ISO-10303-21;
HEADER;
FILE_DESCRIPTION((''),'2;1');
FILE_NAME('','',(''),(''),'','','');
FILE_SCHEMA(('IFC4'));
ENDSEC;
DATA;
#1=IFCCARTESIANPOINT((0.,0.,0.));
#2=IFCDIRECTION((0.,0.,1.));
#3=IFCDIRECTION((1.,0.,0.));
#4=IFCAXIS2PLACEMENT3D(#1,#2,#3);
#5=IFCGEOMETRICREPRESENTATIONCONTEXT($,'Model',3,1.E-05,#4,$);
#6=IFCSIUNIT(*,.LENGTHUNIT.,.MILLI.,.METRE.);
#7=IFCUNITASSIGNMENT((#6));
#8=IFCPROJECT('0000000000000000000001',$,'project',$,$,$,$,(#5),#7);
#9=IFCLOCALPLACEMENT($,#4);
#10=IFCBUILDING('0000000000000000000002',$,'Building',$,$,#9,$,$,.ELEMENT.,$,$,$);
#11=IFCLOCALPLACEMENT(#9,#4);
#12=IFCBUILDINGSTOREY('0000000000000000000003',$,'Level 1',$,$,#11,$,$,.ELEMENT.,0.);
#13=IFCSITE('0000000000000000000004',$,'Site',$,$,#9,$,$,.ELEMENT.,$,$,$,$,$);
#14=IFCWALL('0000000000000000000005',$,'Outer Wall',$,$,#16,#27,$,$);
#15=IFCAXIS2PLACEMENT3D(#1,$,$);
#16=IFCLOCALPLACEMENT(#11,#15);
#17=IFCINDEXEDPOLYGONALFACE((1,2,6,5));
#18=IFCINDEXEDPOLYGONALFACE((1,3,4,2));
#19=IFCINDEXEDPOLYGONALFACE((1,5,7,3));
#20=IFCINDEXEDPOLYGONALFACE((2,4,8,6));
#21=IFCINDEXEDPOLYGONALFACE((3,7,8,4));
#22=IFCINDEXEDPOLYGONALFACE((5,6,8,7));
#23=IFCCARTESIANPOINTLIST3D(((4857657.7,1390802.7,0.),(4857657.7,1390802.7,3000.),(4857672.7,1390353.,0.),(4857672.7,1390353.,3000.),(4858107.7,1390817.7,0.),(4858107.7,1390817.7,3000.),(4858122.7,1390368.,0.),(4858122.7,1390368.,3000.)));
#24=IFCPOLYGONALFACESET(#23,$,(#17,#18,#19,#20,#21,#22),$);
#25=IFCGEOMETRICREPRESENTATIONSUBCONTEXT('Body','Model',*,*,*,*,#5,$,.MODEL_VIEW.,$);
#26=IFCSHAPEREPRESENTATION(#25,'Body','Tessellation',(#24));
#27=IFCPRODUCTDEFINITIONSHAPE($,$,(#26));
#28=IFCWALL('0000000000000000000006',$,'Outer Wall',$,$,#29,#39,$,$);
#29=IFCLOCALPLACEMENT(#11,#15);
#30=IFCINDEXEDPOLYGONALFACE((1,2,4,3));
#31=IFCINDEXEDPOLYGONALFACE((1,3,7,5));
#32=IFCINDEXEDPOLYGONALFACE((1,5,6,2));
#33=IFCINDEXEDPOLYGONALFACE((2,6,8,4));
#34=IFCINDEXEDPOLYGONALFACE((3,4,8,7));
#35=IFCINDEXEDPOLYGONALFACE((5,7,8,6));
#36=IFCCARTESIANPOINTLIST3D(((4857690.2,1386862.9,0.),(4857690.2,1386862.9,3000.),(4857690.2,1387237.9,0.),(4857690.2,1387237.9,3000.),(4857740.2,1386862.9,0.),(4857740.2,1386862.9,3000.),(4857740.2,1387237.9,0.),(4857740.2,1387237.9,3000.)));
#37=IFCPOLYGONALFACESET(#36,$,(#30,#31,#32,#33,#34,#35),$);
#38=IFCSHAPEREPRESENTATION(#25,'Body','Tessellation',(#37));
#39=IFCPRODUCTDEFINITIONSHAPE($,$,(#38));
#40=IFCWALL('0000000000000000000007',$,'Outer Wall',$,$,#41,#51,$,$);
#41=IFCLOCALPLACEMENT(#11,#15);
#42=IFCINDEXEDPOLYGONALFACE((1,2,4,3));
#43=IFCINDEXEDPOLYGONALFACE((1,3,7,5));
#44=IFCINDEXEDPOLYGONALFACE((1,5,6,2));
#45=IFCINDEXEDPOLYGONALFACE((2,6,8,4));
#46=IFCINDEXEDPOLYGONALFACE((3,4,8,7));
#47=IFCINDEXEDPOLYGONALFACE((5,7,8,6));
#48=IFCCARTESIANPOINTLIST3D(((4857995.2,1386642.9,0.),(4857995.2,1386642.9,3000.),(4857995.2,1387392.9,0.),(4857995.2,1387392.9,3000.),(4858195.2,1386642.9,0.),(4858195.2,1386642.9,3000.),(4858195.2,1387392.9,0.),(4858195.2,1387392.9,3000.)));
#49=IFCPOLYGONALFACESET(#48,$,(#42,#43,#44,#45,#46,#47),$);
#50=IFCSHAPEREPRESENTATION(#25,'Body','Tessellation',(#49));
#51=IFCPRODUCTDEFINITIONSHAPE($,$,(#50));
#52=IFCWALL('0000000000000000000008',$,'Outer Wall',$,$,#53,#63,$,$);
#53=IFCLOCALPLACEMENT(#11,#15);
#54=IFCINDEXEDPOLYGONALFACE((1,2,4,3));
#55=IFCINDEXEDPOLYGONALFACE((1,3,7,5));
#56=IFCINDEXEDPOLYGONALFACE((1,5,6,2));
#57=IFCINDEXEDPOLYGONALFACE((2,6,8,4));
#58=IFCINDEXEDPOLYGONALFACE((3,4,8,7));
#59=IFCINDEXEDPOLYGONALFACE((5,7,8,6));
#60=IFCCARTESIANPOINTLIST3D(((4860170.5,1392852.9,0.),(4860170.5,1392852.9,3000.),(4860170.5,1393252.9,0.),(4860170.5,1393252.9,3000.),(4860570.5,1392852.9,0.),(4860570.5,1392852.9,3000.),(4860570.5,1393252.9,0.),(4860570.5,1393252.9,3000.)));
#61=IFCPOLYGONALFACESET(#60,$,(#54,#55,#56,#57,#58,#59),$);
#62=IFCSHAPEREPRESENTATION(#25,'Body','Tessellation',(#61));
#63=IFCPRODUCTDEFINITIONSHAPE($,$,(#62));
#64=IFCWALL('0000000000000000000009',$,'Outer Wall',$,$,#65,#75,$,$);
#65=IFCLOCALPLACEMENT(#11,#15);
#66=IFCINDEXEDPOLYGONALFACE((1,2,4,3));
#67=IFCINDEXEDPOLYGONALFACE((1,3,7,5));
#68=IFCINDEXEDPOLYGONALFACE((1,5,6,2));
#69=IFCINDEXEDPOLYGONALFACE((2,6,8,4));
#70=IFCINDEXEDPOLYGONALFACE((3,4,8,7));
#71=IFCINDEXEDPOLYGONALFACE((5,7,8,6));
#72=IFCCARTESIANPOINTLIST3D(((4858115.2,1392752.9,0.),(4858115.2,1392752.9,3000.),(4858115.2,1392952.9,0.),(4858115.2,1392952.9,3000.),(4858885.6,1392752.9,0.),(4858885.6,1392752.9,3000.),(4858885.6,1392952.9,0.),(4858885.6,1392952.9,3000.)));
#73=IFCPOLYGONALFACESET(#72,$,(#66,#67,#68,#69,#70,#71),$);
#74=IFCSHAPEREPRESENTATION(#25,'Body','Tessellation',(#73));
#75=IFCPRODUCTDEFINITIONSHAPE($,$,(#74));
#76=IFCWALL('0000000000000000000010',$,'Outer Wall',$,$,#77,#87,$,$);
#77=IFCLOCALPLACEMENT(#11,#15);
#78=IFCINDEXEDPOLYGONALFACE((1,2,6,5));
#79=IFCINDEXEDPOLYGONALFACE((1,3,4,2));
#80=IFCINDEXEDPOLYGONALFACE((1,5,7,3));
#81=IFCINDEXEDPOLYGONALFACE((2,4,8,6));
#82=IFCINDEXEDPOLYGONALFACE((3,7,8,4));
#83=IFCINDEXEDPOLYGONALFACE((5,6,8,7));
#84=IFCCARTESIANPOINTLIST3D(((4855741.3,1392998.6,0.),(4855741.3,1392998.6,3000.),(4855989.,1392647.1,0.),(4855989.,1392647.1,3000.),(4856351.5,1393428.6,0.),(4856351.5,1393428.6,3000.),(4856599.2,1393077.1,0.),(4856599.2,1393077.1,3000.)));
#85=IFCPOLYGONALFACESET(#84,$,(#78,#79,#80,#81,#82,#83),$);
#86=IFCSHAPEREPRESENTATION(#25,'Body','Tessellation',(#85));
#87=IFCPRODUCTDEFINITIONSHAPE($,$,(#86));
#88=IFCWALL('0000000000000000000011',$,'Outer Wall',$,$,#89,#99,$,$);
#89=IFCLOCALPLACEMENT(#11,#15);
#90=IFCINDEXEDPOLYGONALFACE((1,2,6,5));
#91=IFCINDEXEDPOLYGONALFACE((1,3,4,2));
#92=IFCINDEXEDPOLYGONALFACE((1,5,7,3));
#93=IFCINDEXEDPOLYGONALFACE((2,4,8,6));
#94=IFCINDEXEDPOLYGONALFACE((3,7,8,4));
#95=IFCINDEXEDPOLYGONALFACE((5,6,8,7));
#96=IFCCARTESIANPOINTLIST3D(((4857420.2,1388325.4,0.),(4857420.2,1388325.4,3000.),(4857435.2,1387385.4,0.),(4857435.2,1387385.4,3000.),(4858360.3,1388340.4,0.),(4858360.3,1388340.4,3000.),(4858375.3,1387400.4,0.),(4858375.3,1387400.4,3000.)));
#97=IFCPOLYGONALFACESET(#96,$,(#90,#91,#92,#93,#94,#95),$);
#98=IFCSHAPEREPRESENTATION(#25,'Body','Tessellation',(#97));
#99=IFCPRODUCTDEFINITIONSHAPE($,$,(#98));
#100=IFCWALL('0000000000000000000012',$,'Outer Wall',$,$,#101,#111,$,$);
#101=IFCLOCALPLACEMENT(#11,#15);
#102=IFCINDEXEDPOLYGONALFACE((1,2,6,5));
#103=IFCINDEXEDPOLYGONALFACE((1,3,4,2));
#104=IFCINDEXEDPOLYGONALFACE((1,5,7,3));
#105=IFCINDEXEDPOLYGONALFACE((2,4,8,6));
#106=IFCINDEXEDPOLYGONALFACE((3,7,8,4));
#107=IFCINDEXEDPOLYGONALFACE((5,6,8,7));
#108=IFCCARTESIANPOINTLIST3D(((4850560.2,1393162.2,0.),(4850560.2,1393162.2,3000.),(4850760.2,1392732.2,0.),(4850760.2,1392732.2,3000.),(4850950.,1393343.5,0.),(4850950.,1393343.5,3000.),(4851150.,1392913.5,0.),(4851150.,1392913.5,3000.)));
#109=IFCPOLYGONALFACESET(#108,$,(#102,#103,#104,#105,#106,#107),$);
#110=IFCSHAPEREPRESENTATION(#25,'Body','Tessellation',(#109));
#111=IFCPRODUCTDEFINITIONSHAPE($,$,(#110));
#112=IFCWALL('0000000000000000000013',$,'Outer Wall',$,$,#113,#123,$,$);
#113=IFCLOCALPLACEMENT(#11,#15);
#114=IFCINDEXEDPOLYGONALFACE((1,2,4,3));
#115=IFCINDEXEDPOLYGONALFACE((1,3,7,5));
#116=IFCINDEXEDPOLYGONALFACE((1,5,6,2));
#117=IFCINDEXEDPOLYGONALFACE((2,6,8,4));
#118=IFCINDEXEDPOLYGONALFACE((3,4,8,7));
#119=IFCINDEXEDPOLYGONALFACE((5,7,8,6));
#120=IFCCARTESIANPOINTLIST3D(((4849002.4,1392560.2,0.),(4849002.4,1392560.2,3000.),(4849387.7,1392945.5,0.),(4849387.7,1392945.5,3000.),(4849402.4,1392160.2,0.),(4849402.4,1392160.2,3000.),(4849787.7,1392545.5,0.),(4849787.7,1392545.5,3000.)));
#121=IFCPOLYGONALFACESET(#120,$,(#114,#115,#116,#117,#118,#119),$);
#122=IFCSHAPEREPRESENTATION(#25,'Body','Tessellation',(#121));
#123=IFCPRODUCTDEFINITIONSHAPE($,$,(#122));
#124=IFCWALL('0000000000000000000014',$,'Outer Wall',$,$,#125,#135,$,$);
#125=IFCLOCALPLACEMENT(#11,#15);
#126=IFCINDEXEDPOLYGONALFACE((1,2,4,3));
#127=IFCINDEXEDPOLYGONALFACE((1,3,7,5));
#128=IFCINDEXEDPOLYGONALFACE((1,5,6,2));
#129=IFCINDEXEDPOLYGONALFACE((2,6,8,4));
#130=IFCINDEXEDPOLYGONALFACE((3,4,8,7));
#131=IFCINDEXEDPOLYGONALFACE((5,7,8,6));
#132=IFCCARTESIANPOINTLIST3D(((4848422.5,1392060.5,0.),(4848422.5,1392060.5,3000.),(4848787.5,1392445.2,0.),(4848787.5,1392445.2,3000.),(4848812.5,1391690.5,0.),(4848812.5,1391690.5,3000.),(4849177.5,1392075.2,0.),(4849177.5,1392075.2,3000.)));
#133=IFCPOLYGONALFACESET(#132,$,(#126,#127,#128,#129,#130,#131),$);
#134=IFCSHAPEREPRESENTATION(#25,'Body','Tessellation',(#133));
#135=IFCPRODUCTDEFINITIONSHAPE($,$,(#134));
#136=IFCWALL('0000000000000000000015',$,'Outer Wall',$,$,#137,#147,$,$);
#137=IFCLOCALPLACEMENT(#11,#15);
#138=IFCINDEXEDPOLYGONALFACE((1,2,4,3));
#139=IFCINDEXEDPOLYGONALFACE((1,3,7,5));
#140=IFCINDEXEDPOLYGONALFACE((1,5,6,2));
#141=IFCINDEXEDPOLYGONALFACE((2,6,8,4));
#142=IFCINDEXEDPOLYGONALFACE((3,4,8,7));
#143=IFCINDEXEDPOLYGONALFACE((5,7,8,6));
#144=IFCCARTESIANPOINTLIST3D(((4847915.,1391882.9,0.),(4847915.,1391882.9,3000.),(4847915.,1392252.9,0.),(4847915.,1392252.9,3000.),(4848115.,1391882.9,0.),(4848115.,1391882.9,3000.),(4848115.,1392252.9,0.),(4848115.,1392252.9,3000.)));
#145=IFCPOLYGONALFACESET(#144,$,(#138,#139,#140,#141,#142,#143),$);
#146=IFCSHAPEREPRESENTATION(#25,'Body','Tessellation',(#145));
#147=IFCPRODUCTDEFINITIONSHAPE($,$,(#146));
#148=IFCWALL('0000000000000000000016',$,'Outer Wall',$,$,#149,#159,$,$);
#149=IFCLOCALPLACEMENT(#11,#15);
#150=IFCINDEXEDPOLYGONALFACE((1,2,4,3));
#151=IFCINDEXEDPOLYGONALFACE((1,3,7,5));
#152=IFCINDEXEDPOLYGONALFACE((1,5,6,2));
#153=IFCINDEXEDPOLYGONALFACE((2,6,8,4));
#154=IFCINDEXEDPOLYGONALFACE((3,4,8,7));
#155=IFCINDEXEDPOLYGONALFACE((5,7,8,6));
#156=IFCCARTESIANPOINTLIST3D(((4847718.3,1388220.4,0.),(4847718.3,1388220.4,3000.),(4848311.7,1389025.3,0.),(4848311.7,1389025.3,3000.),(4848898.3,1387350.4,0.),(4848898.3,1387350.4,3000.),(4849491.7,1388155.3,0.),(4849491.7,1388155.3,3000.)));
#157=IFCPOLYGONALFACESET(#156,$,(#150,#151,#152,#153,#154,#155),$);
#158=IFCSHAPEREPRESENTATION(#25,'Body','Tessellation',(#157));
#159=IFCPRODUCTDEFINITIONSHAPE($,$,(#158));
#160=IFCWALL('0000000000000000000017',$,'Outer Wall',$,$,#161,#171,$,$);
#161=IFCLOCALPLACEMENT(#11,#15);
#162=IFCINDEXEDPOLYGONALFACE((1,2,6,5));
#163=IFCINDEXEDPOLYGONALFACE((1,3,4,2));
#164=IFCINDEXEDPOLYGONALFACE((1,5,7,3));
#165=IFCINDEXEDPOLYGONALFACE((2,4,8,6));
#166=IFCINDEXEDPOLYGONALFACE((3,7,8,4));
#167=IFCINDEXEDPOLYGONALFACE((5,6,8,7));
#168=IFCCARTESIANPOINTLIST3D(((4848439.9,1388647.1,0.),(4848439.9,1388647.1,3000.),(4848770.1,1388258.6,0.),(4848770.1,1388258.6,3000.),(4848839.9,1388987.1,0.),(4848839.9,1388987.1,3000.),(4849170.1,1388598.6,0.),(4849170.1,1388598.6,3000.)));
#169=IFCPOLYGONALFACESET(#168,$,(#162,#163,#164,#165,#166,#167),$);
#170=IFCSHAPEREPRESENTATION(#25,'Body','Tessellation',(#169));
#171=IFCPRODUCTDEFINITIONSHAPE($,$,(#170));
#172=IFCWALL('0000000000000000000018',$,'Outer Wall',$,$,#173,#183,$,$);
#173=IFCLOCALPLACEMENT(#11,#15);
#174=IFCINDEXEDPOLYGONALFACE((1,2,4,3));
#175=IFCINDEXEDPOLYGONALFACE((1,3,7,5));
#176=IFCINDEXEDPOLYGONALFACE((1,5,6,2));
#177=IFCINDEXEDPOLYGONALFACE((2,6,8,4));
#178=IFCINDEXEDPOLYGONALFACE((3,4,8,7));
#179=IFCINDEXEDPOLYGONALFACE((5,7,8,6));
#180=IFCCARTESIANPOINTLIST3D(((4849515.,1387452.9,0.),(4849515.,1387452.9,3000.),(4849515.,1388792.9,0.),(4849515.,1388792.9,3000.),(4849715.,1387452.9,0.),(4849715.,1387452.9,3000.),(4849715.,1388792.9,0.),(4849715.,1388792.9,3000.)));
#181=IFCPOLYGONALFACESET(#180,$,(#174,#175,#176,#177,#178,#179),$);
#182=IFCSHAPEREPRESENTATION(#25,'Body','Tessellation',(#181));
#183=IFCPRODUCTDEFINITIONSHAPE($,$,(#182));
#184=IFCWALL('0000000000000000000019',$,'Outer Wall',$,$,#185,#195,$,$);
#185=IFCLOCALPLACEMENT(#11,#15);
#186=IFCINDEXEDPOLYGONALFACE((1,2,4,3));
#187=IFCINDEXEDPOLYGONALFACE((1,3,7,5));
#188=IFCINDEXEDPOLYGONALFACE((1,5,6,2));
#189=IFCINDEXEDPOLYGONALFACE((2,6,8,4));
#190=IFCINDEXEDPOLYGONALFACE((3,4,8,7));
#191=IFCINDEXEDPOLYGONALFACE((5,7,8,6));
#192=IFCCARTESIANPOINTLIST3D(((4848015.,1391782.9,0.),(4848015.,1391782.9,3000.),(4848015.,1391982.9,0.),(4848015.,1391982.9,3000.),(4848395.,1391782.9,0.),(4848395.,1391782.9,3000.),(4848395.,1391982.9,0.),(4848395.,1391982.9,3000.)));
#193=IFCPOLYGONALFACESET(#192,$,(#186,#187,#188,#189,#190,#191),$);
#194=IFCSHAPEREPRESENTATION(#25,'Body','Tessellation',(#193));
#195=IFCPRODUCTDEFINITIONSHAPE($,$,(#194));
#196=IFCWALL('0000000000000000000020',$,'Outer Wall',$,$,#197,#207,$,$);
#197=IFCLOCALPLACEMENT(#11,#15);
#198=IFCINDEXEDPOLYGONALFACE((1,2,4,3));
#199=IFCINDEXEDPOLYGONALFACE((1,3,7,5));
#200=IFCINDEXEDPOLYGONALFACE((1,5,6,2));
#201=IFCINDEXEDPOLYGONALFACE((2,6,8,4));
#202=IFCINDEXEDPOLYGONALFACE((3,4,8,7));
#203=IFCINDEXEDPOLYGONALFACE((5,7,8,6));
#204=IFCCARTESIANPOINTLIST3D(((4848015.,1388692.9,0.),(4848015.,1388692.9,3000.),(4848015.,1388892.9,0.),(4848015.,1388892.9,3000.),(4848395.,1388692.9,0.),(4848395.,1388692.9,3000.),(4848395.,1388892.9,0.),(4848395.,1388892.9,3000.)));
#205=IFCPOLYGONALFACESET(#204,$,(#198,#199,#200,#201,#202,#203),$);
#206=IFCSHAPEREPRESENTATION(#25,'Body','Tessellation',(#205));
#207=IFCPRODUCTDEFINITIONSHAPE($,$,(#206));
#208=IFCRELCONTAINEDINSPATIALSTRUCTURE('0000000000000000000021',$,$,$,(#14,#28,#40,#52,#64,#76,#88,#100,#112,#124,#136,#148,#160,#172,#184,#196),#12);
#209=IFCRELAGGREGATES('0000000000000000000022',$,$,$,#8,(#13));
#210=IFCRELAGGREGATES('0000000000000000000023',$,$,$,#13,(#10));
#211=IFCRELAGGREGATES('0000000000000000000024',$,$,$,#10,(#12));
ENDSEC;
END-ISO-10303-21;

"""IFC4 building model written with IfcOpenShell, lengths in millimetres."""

from ifc_helpers import new_model, si_unit, frame, frame_2d, origin_with_axes, place, context, subcontext, project, spatial, rectangle, extrude, element, save


model = new_model("IFC4")

# Units and contexts
model_context = context("Model", 3, precision=1e-05, world=origin_with_axes())
body_context = subcontext(model_context, "Body", "Model", "MODEL_VIEW")
ifc_project = project(units=[si_unit("LENGTHUNIT", "METRE", prefix="MILLI")], contexts=[model_context])

# Site, building, storey
placement = place(None, origin_with_axes())
site = spatial("IfcSite", under=ifc_project, at=placement, Name="Site", CompositionType="ELEMENT")
building = spatial("IfcBuilding", under=site, at=placement, Name="Building", CompositionType="ELEMENT")
storey_placement = place(placement, origin_with_axes())
storey = spatial("IfcBuildingStorey", under=building, at=storey_placement, Name="Level 1", CompositionType="ELEMENT", Elevation=0.0)

# Walls
wall_1_placement = place(placement, frame((4857665.2, 1390577.9, 0.0), z_axis=(0.0, 0.0, 1.0), x_axis=(0.999445, 0.033315, 0.0)))
element("IfcWall", 1, at=wall_1_placement, inside=storey, Name="Outer Wall", context=body_context, shape_type="SweptSolid", body=[
    extrude(rectangle(XDim=450.2, YDim=450.0, at=frame_2d((225.1, 0.0), x_axis=(1.0, 0.0))), origin_with_axes(), (0.0, 0.0, 1.0), 3000.0),
])
wall_2_placement = place(placement, frame((4857715.2, 1387237.9, 0.0), z_axis=(0.0, 0.0, 1.0), x_axis=(0.0, -1.0, 0.0)))
element("IfcWall", 2, at=wall_2_placement, inside=storey, Name="Outer Wall", context=body_context, shape_type="SweptSolid", body=[
    extrude(rectangle(XDim=375.0, YDim=50.0, at=frame_2d((187.5, 0.0), x_axis=(1.0, 0.0))), origin_with_axes(), (0.0, 0.0, 1.0), 3000.0),
])
wall_3_placement = place(placement, frame((4858095.2, 1387392.9, 0.0), z_axis=(0.0, 0.0, 1.0), x_axis=(0.0, -1.0, 0.0)))
element("IfcWall", 3, at=wall_3_placement, inside=storey, Name="Outer Wall", context=body_context, shape_type="SweptSolid", body=[
    extrude(rectangle(XDim=750.0, YDim=200.0, at=frame_2d((375.0, 0.0), x_axis=(1.0, 0.0))), origin_with_axes(), (0.0, 0.0, 1.0), 3000.0),
])
wall_4_placement = place(placement, frame((4860370.5, 1392852.9, 0.0), z_axis=(0.0, 0.0, 1.0), x_axis=(0.0, 1.0, 0.0)))
element("IfcWall", 4, at=wall_4_placement, inside=storey, Name="Outer Wall", context=body_context, shape_type="SweptSolid", body=[
    extrude(rectangle(XDim=400.0, YDim=400.0, at=frame_2d((200.0, 0.0), x_axis=(1.0, 0.0))), origin_with_axes(), (0.0, 0.0, 1.0), 3000.0),
])
wall_5_placement = place(placement, frame((4858885.6, 1392852.9, 0.0), z_axis=(0.0, 0.0, 1.0), x_axis=(-1.0, 0.0, 0.0)))
element("IfcWall", 5, at=wall_5_placement, inside=storey, Name="Outer Wall", context=body_context, shape_type="SweptSolid", body=[
    extrude(rectangle(XDim=770.4, YDim=200.0, at=frame_2d((385.2, 0.0), x_axis=(1.0, 0.0))), origin_with_axes(), (0.0, 0.0, 1.0), 3000.0),
])
wall_6_placement = place(placement, frame((4855865.2, 1392822.9, 0.0), z_axis=(0.0, 0.0, 1.0), x_axis=(0.817428, 0.576031, 0.0)))
element("IfcWall", 6, at=wall_6_placement, inside=storey, Name="Outer Wall", context=body_context, shape_type="SweptSolid", body=[
    extrude(rectangle(XDim=746.5, YDim=430.0, at=frame_2d((373.2, 0.0), x_axis=(1.0, 0.0))), origin_with_axes(), (0.0, 0.0, 1.0), 3000.0),
])
wall_7_placement = place(placement, frame((4857890.2, 1388332.9, 0.0), z_axis=(0.0, 0.0, 1.0), x_axis=(0.015955, -0.999873, 0.0)))
element("IfcWall", 7, at=wall_7_placement, inside=storey, Name="Outer Wall", context=body_context, shape_type="SweptSolid", body=[
    extrude(rectangle(XDim=940.1, YDim=940.2, at=frame_2d((470.1, 0.0), x_axis=(1.0, 0.0))), origin_with_axes(), (0.0, 0.0, 1.0), 3000.0),
])
wall_8_placement = place(placement, frame((4850955.1, 1392822.9, 0.0), z_axis=(0.0, 0.0, 1.0), x_axis=(-0.421731, 0.906721, 0.0)))
element("IfcWall", 8, at=wall_8_placement, inside=storey, Name="Outer Wall", context=body_context, shape_type="SweptSolid", body=[
    extrude(rectangle(XDim=474.2, YDim=430.0, at=frame_2d((237.1, 0.0), x_axis=(1.0, 0.0))), origin_with_axes(), (0.0, 0.0, 1.0), 3000.0),
])
wall_9_placement = place(placement, frame((4849195.0, 1392752.9, 0.0), z_axis=(0.0, 0.0, 1.0), x_axis=(0.707107, -0.707107, 0.0)))
element("IfcWall", 9, at=wall_9_placement, inside=storey, Name="Outer Wall", context=body_context, shape_type="SweptSolid", body=[
    extrude(rectangle(XDim=565.7, YDim=544.9, at=frame_2d((282.8, 0.0), x_axis=(1.0, 0.0))), origin_with_axes(), (0.0, 0.0, 1.0), 3000.0),
])
wall_10_placement = place(placement, frame((4848995.0, 1391882.9, 0.0), z_axis=(0.0, 0.0, 1.0), x_axis=(-0.725464, 0.68826, 0.0)))
element("IfcWall", 10, at=wall_10_placement, inside=storey, Name="Outer Wall", context=body_context, shape_type="SweptSolid", body=[
    extrude(rectangle(XDim=537.6, YDim=530.4, at=frame_2d((268.8, 0.0), x_axis=(1.0, 0.0))), origin_with_axes(), (0.0, 0.0, 1.0), 3000.0),
])
wall_11_placement = place(placement, frame((4848015.0, 1392252.9, 0.0), z_axis=(0.0, 0.0, 1.0), x_axis=(0.0, -1.0, 0.0)))
element("IfcWall", 11, at=wall_11_placement, inside=storey, Name="Outer Wall", context=body_context, shape_type="SweptSolid", body=[
    extrude(rectangle(XDim=370.0, YDim=200.0, at=frame_2d((185.0, 0.0), x_axis=(1.0, 0.0))), origin_with_axes(), (0.0, 0.0, 1.0), 3000.0),
])
wall_12_placement = place(placement, frame((4848015.0, 1388622.9, 0.0), z_axis=(0.0, 0.0, 1.0), x_axis=(0.804884, -0.593432, 0.0)))
element("IfcWall", 12, at=wall_12_placement, inside=storey, Name="Outer Wall", context=body_context, shape_type="SweptSolid", body=[
    extrude(rectangle(XDim=1466.0, YDim=1000.0, at=frame_2d((733.0, 0.0), x_axis=(1.0, 0.0))), origin_with_axes(), (0.0, 0.0, 1.0), 3000.0),
])
wall_13_placement = place(placement, frame((4849005.0, 1388792.9, 0.0), z_axis=(0.0, 0.0, 1.0), x_axis=(-0.761939, -0.647648, 0.0)))
element("IfcWall", 13, at=wall_13_placement, inside=storey, Name="Outer Wall", context=body_context, shape_type="SweptSolid", body=[
    extrude(rectangle(XDim=525.0, YDim=509.9, at=frame_2d((262.5, 0.0), x_axis=(1.0, 0.0))), origin_with_axes(), (0.0, 0.0, 1.0), 3000.0),
])
wall_14_placement = place(placement, frame((4849615.0, 1387452.9, 0.0), z_axis=(0.0, 0.0, 1.0), x_axis=(0.0, 1.0, 0.0)))
element("IfcWall", 14, at=wall_14_placement, inside=storey, Name="Outer Wall", context=body_context, shape_type="SweptSolid", body=[
    extrude(rectangle(XDim=1340.0, YDim=200.0, at=frame_2d((670.0, 0.0), x_axis=(1.0, 0.0))), origin_with_axes(), (0.0, 0.0, 1.0), 3000.0),
])
for number, where, z_axis, x_axis, name in (
    (15, (4848015.0, 1391882.9, 0.0), (0.0, 0.0, 1.0), (1.0, 0.0, 0.0), "Outer Wall"),
    (16, (4848015.0, 1388792.9, 0.0), (0.0, 0.0, 1.0), (1.0, 0.0, 0.0), "Outer Wall"),
):
    element("IfcWall", number, at=place(placement, frame(where, z_axis=z_axis, x_axis=x_axis)), inside=storey, Name=name, context=body_context, shape_type="SweptSolid", body=[
        extrude(rectangle(XDim=380.0, YDim=200.0, at=frame_2d((190.0, 0.0), x_axis=(1.0, 0.0))), origin_with_axes(), (0.0, 0.0, 1.0), 3000.0),
    ])

save(model, "model.ifc")
